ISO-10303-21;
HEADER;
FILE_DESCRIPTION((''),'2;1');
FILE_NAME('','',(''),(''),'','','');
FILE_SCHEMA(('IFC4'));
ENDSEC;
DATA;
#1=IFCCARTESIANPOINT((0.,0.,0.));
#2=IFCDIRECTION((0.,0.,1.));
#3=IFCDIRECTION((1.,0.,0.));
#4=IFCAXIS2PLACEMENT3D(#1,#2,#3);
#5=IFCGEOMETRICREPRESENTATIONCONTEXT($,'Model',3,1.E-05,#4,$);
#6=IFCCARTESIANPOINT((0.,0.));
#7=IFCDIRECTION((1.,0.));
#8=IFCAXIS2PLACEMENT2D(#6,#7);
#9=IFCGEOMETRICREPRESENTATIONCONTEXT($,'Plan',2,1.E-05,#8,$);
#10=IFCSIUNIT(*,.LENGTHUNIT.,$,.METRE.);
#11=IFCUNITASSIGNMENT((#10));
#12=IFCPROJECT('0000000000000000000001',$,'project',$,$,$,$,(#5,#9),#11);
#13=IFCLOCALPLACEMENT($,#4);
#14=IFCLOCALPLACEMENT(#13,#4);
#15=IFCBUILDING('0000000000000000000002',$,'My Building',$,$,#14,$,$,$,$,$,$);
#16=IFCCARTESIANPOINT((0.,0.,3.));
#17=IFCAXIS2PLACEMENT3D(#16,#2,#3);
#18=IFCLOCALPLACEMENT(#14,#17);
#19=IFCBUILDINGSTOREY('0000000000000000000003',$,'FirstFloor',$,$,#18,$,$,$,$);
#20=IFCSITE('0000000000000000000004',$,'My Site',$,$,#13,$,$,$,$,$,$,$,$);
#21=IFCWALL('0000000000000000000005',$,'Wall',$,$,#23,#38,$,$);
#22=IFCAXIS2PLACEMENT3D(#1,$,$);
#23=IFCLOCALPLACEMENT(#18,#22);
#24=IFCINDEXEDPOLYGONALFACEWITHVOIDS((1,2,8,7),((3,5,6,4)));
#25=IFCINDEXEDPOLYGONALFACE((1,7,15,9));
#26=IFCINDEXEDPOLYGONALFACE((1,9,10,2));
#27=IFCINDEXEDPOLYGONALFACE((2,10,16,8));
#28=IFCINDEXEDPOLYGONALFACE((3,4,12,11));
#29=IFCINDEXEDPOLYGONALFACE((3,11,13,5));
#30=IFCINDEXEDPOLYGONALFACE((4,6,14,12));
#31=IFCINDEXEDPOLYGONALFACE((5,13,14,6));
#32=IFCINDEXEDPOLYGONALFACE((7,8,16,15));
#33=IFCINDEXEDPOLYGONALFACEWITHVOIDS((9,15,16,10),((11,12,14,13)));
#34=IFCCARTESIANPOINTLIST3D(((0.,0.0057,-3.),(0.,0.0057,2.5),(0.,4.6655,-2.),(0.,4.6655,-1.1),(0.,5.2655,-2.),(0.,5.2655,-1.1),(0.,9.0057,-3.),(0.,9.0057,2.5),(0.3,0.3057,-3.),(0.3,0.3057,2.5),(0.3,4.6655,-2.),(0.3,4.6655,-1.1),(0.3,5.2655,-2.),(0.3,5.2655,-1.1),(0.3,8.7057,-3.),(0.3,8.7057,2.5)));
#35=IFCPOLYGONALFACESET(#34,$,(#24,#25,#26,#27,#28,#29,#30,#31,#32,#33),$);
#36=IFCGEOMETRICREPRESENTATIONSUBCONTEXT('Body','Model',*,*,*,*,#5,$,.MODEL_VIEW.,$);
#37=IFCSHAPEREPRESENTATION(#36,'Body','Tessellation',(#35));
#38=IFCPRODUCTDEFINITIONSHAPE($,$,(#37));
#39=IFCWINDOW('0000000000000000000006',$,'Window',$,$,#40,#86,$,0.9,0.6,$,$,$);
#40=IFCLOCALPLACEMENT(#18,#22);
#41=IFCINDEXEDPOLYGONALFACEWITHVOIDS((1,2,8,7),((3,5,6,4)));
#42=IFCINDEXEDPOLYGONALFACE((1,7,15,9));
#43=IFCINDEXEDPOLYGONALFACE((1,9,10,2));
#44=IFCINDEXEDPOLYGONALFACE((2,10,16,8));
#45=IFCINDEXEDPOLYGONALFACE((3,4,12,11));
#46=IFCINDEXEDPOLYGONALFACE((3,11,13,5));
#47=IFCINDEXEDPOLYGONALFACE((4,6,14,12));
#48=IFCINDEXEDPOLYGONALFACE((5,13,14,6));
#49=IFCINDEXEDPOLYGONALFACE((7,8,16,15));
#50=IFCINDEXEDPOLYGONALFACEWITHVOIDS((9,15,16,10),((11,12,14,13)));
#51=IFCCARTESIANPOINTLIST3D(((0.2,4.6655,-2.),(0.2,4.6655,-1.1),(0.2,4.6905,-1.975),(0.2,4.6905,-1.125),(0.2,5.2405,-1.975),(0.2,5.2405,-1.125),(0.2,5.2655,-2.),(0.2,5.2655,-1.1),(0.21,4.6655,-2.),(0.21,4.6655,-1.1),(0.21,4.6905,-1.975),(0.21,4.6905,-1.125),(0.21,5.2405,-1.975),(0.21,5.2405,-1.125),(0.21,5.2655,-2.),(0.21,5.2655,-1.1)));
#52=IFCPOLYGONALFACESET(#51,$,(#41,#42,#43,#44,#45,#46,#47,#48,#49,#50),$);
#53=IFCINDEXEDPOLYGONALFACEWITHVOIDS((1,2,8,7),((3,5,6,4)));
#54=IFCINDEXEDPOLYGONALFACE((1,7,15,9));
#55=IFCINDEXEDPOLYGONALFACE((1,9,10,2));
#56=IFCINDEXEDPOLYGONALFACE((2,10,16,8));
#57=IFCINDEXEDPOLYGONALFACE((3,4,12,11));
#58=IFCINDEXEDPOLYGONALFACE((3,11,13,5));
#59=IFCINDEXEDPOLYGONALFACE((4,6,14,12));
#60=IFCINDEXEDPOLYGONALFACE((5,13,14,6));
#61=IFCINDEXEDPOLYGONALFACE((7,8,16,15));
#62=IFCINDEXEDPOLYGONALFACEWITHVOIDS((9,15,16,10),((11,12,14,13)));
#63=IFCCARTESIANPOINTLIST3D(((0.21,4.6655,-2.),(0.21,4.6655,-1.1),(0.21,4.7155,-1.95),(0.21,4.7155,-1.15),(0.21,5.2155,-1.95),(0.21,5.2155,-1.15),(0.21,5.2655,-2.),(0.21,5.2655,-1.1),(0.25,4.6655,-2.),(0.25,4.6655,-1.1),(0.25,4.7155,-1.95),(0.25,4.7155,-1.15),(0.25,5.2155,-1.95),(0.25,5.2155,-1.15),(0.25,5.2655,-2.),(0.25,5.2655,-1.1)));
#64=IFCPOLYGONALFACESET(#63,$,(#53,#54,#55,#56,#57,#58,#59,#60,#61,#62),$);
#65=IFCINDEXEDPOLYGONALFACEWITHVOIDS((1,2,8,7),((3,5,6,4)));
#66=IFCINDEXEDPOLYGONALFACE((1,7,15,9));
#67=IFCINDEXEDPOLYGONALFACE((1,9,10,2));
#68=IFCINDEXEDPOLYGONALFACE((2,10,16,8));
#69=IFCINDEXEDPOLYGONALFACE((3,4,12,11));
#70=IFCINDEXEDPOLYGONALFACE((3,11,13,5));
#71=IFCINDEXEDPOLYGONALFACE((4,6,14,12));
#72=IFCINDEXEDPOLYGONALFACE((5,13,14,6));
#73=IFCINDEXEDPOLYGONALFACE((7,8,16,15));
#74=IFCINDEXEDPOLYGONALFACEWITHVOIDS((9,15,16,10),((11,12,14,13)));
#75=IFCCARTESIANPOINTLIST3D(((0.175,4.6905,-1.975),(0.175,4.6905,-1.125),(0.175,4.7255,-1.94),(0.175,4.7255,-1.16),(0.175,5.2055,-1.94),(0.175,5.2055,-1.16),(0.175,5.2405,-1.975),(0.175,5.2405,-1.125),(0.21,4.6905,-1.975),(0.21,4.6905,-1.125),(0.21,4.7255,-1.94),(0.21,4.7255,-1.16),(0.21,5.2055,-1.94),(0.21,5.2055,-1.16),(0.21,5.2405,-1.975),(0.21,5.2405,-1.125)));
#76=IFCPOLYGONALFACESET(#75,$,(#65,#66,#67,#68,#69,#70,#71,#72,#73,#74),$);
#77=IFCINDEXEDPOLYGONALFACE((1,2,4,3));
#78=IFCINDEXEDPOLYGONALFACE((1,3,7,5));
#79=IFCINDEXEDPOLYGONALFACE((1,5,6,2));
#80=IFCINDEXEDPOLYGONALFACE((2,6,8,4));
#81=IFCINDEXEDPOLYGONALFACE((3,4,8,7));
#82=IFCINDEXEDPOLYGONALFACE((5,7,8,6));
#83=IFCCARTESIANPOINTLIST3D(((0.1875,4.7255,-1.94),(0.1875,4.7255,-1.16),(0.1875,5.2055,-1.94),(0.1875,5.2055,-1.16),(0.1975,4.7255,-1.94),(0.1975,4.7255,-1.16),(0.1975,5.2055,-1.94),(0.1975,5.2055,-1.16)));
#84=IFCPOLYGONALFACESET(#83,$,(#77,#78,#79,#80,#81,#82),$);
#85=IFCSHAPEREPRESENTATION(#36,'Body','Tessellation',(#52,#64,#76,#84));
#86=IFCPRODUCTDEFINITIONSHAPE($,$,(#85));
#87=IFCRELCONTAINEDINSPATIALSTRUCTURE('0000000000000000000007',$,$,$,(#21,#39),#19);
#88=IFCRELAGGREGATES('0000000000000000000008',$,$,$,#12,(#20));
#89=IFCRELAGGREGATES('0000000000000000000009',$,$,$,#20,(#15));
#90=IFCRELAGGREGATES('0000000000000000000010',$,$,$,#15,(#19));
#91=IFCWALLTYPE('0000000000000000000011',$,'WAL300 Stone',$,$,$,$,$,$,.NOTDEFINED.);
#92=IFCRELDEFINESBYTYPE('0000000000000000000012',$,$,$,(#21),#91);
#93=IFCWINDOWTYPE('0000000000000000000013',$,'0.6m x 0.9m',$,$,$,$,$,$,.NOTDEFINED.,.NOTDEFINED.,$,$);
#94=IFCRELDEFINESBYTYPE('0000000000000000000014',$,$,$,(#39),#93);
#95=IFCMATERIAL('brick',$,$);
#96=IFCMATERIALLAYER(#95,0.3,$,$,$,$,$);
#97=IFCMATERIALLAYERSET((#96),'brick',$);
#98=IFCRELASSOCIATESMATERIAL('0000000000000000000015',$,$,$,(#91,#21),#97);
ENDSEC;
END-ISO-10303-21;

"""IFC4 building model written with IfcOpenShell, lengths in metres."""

from ifc_helpers import new_model, entity, si_unit, frame, origin_with_axes, origin_2d_with_axis, place, context, subcontext, project, spatial, line, indexed_curve, outline, extrude, shape, source, transform, mapped, material, layer, layer_set, layer_usage, type_object, type_shapes, element, fill, save


model = new_model("IFC4")

# Units and contexts
model_context = context("Model", 3, precision=1e-05, world=origin_with_axes())
plan_context = context("Plan", 2, precision=1e-05, world=origin_2d_with_axis())
body_context_1 = subcontext(model_context, "Body", "Model", "MODEL_VIEW")
body_context_2 = subcontext(plan_context, "Body", "Plan", "PLAN_VIEW")
ifc_project = project(units=[si_unit("LENGTHUNIT", "METRE")], contexts=[model_context, plan_context])

# Site, building, storey
site_placement = place(None, origin_with_axes())
site = spatial("IfcSite", under=ifc_project, at=site_placement, Name="My Site")
building_placement = place(site_placement, origin_with_axes())
building = spatial("IfcBuilding", under=site, at=building_placement, Name="My Building")
storey_placement = place(building_placement, frame((0.0, 0.0, 3.0), z_axis=(0.0, 0.0, 1.0), x_axis=(1.0, 0.0, 0.0)))
storey = spatial("IfcBuildingStorey", under=building, at=storey_placement, Name="FirstFloor")

# Wall, opening, window
ifc_material = material(Name="brick")
ifc_layer = layer(ifc_material, 0.3)
ifc_layer_set = layer_set([ifc_layer], Name="brick")
ifc_layer_usage_1 = layer_usage(ifc_layer_set, "AXIS2", "POSITIVE", 0.0)
wall_type = type_object("IfcWallType", Name="WAL300 Stone", PredefinedType="NOTDEFINED", material=ifc_layer_set)
wall_1_placement = place(storey_placement, frame((0.3, 0.3057, -3.0), z_axis=(0.0, 0.0, 1.0), x_axis=(0.0, 1.0, 0.0)))
wall_1 = element("IfcWall", 1, at=wall_1_placement, inside=storey, type_object=wall_type, material=ifc_layer_usage_1, Name="Wall", context=body_context_1, shape_type="SweptSolid", body=[
    extrude(outline(indexed_curve([(0.0, 0.0), (-0.3, 0.3), (8.7, 0.3), (8.4, 0.0)], segments=[line(1, 2, 3, 4, 1)])), origin_with_axes(), (0.0, 0.0, 1.0), 5.5),
])
shared_shape_1 = source(origin_with_axes(), body_context_1, "Body", "SweptSolid", [
    extrude(outline(indexed_curve([(0.0, 0.0), (0.6, 0.0), (0.6, 0.9), (0.0, 0.9)], segments=[line(1, 2, 3, 4, 1)])), frame((0.0, -0.6, 0.0), z_axis=(0.0, -1.0, 0.0), x_axis=(1.0, 0.0, 0.0)), (0.0, 0.0, -1.0), 1.2),
])
opening_1_placement = place(wall_1_placement, frame((4.3598, 0.0, 1.0), z_axis=(0.0, 0.0, 1.0), x_axis=(1.0, 0.0, 0.0)))
opening_1 = element("IfcOpeningElement", 2, at=opening_1_placement, cuts=wall_1, PredefinedType="OPENING", context=body_context_1, shape_type="MappedRepresentation", body=[
    mapped(shared_shape_1, transform((0.0, 0.0, 0.0), x_axis=(1.0, 0.0, 0.0), y_axis=(0.0, 1.0, 0.0), z_axis=(0.0, 0.0, 1.0), scale=1.0)),
])
window_type_1 = type_object("IfcWindowType", Name="0.6m x 0.9m", PartitioningType="NOTDEFINED", PredefinedType="NOTDEFINED")
shared_shape_2 = source(origin_with_axes(), body_context_1, "Body", "SweptSolid", [
    extrude(outline(indexed_curve([(0.0, 0.0), (0.6, 0.0), (0.6, 0.9), (0.0, 0.9)], segments=[line(1, 2, 3, 4, 1)]), holes=[indexed_curve([(0.025, 0.025), (0.575, 0.025), (0.575, 0.875), (0.025, 0.875)], segments=[line(1, 2, 3, 4, 1)])]), frame((0.0, 0.09, 0.0), z_axis=(0.0, -1.0, 0.0), x_axis=(1.0, 0.0, 0.0)), (0.0, 0.0, -1.0), 0.01),
    extrude(outline(indexed_curve([(0.0, 0.0), (0.6, 0.0), (0.6, 0.9), (0.0, 0.9)], segments=[line(1, 2, 3, 4, 1)]), holes=[indexed_curve([(0.05, 0.05), (0.55, 0.05), (0.55, 0.85), (0.05, 0.85)], segments=[line(1, 2, 3, 4, 1)])]), frame((0.0, 0.05, 0.0), z_axis=(0.0, -1.0, 0.0), x_axis=(1.0, 0.0, 0.0)), (0.0, 0.0, -1.0), 0.04),
    extrude(outline(indexed_curve([(0.0, 0.0), (0.55, 0.0), (0.55, 0.85), (0.0, 0.85)], segments=[line(1, 2, 3, 4, 1)]), holes=[indexed_curve([(0.035, 0.035), (0.515, 0.035), (0.515, 0.815), (0.035, 0.815)], segments=[line(1, 2, 3, 4, 1)])]), frame((0.025, 0.09, 0.025), z_axis=(0.0, -1.0, 0.0), x_axis=(1.0, 0.0, 0.0)), (0.0, 0.0, -1.0), 0.035),
    extrude(outline(indexed_curve([(0.035, 0.035), (0.515, 0.035), (0.515, 0.815), (0.035, 0.815)], segments=[line(1, 2, 3, 4, 1)])), frame((0.025, 0.1025, 0.025), z_axis=(0.0, -1.0, 0.0), x_axis=(1.0, 0.0, 0.0)), (0.0, 0.0, -1.0), 0.01),
])
shared_shape_3 = source(origin_with_axes(), body_context_2, "Body", "Curve2D", [
    entity("IfcIndexedPolyCurve", entity("IfcCartesianPointList2D", [[0.05, 0.05], [0.55, 0.05]])),
    entity("IfcIndexedPolyCurve", entity("IfcCartesianPointList2D", [[0.0, 0.1], [0.025, 0.1], [0.025, 0.09], [0.05, 0.09], [0.05, 0.05], [0.0, 0.05]]), [entity("IfcLineIndex", [1, 2, 3, 4, 5, 6, 1])]),
    entity("IfcIndexedPolyCurve", entity("IfcCartesianPointList2D", [[0.6, 0.1], [0.575, 0.1], [0.575, 0.09], [0.55, 0.09], [0.55, 0.05], [0.6, 0.05]]), [entity("IfcLineIndex", [1, 2, 3, 4, 5, 6, 1])]),
    entity("IfcIndexedPolyCurve", entity("IfcCartesianPointList2D", [[0.025, 0.09], [0.06, 0.09], [0.06, 0.125], [0.025, 0.125]]), [entity("IfcLineIndex", [1, 2, 3, 4, 1])]),
    entity("IfcIndexedPolyCurve", entity("IfcCartesianPointList2D", [[0.575, 0.09], [0.54, 0.09], [0.54, 0.125], [0.575, 0.125]]), [entity("IfcLineIndex", [1, 2, 3, 4, 1])]),
    entity("IfcIndexedPolyCurve", entity("IfcCartesianPointList2D", [[0.06, 0.09], [0.54, 0.09]])),
    entity("IfcIndexedPolyCurve", entity("IfcCartesianPointList2D", [[0.06, 0.125], [0.54, 0.125]])),
    entity("IfcIndexedPolyCurve", entity("IfcCartesianPointList2D", [[0.06, 0.1075], [0.54, 0.1075]])),
])
type_shapes(window_type_1, [shared_shape_2, shared_shape_3])
window_1_placement = place(opening_1_placement, frame((0.0, 0.0, 0.0), z_axis=(0.0, 0.0, 1.0), x_axis=(1.0, 0.0, 0.0)))
window_1 = element("IfcWindow", 3, at=window_1_placement, inside=storey, type_object=window_type_1, Name="Window", OverallHeight=0.9, OverallWidth=0.6, shapes=[
    shape(body_context_1, "Body", "MappedRepresentation", [mapped(shared_shape_2, transform((0.0, 0.0, 0.0), x_axis=(1.0, 0.0, 0.0), y_axis=(0.0, 1.0, 0.0), z_axis=(0.0, 0.0, 1.0), scale=1.0))]),
    shape(body_context_2, "Body", "MappedRepresentation", [mapped(shared_shape_3, transform((0.0, 0.0, 0.0), x_axis=(1.0, 0.0, 0.0), y_axis=(0.0, 1.0, 0.0), z_axis=(0.0, 0.0, 1.0), scale=1.0))]),
])
fill(opening_1, window_1)

save(model, "model.ifc")
